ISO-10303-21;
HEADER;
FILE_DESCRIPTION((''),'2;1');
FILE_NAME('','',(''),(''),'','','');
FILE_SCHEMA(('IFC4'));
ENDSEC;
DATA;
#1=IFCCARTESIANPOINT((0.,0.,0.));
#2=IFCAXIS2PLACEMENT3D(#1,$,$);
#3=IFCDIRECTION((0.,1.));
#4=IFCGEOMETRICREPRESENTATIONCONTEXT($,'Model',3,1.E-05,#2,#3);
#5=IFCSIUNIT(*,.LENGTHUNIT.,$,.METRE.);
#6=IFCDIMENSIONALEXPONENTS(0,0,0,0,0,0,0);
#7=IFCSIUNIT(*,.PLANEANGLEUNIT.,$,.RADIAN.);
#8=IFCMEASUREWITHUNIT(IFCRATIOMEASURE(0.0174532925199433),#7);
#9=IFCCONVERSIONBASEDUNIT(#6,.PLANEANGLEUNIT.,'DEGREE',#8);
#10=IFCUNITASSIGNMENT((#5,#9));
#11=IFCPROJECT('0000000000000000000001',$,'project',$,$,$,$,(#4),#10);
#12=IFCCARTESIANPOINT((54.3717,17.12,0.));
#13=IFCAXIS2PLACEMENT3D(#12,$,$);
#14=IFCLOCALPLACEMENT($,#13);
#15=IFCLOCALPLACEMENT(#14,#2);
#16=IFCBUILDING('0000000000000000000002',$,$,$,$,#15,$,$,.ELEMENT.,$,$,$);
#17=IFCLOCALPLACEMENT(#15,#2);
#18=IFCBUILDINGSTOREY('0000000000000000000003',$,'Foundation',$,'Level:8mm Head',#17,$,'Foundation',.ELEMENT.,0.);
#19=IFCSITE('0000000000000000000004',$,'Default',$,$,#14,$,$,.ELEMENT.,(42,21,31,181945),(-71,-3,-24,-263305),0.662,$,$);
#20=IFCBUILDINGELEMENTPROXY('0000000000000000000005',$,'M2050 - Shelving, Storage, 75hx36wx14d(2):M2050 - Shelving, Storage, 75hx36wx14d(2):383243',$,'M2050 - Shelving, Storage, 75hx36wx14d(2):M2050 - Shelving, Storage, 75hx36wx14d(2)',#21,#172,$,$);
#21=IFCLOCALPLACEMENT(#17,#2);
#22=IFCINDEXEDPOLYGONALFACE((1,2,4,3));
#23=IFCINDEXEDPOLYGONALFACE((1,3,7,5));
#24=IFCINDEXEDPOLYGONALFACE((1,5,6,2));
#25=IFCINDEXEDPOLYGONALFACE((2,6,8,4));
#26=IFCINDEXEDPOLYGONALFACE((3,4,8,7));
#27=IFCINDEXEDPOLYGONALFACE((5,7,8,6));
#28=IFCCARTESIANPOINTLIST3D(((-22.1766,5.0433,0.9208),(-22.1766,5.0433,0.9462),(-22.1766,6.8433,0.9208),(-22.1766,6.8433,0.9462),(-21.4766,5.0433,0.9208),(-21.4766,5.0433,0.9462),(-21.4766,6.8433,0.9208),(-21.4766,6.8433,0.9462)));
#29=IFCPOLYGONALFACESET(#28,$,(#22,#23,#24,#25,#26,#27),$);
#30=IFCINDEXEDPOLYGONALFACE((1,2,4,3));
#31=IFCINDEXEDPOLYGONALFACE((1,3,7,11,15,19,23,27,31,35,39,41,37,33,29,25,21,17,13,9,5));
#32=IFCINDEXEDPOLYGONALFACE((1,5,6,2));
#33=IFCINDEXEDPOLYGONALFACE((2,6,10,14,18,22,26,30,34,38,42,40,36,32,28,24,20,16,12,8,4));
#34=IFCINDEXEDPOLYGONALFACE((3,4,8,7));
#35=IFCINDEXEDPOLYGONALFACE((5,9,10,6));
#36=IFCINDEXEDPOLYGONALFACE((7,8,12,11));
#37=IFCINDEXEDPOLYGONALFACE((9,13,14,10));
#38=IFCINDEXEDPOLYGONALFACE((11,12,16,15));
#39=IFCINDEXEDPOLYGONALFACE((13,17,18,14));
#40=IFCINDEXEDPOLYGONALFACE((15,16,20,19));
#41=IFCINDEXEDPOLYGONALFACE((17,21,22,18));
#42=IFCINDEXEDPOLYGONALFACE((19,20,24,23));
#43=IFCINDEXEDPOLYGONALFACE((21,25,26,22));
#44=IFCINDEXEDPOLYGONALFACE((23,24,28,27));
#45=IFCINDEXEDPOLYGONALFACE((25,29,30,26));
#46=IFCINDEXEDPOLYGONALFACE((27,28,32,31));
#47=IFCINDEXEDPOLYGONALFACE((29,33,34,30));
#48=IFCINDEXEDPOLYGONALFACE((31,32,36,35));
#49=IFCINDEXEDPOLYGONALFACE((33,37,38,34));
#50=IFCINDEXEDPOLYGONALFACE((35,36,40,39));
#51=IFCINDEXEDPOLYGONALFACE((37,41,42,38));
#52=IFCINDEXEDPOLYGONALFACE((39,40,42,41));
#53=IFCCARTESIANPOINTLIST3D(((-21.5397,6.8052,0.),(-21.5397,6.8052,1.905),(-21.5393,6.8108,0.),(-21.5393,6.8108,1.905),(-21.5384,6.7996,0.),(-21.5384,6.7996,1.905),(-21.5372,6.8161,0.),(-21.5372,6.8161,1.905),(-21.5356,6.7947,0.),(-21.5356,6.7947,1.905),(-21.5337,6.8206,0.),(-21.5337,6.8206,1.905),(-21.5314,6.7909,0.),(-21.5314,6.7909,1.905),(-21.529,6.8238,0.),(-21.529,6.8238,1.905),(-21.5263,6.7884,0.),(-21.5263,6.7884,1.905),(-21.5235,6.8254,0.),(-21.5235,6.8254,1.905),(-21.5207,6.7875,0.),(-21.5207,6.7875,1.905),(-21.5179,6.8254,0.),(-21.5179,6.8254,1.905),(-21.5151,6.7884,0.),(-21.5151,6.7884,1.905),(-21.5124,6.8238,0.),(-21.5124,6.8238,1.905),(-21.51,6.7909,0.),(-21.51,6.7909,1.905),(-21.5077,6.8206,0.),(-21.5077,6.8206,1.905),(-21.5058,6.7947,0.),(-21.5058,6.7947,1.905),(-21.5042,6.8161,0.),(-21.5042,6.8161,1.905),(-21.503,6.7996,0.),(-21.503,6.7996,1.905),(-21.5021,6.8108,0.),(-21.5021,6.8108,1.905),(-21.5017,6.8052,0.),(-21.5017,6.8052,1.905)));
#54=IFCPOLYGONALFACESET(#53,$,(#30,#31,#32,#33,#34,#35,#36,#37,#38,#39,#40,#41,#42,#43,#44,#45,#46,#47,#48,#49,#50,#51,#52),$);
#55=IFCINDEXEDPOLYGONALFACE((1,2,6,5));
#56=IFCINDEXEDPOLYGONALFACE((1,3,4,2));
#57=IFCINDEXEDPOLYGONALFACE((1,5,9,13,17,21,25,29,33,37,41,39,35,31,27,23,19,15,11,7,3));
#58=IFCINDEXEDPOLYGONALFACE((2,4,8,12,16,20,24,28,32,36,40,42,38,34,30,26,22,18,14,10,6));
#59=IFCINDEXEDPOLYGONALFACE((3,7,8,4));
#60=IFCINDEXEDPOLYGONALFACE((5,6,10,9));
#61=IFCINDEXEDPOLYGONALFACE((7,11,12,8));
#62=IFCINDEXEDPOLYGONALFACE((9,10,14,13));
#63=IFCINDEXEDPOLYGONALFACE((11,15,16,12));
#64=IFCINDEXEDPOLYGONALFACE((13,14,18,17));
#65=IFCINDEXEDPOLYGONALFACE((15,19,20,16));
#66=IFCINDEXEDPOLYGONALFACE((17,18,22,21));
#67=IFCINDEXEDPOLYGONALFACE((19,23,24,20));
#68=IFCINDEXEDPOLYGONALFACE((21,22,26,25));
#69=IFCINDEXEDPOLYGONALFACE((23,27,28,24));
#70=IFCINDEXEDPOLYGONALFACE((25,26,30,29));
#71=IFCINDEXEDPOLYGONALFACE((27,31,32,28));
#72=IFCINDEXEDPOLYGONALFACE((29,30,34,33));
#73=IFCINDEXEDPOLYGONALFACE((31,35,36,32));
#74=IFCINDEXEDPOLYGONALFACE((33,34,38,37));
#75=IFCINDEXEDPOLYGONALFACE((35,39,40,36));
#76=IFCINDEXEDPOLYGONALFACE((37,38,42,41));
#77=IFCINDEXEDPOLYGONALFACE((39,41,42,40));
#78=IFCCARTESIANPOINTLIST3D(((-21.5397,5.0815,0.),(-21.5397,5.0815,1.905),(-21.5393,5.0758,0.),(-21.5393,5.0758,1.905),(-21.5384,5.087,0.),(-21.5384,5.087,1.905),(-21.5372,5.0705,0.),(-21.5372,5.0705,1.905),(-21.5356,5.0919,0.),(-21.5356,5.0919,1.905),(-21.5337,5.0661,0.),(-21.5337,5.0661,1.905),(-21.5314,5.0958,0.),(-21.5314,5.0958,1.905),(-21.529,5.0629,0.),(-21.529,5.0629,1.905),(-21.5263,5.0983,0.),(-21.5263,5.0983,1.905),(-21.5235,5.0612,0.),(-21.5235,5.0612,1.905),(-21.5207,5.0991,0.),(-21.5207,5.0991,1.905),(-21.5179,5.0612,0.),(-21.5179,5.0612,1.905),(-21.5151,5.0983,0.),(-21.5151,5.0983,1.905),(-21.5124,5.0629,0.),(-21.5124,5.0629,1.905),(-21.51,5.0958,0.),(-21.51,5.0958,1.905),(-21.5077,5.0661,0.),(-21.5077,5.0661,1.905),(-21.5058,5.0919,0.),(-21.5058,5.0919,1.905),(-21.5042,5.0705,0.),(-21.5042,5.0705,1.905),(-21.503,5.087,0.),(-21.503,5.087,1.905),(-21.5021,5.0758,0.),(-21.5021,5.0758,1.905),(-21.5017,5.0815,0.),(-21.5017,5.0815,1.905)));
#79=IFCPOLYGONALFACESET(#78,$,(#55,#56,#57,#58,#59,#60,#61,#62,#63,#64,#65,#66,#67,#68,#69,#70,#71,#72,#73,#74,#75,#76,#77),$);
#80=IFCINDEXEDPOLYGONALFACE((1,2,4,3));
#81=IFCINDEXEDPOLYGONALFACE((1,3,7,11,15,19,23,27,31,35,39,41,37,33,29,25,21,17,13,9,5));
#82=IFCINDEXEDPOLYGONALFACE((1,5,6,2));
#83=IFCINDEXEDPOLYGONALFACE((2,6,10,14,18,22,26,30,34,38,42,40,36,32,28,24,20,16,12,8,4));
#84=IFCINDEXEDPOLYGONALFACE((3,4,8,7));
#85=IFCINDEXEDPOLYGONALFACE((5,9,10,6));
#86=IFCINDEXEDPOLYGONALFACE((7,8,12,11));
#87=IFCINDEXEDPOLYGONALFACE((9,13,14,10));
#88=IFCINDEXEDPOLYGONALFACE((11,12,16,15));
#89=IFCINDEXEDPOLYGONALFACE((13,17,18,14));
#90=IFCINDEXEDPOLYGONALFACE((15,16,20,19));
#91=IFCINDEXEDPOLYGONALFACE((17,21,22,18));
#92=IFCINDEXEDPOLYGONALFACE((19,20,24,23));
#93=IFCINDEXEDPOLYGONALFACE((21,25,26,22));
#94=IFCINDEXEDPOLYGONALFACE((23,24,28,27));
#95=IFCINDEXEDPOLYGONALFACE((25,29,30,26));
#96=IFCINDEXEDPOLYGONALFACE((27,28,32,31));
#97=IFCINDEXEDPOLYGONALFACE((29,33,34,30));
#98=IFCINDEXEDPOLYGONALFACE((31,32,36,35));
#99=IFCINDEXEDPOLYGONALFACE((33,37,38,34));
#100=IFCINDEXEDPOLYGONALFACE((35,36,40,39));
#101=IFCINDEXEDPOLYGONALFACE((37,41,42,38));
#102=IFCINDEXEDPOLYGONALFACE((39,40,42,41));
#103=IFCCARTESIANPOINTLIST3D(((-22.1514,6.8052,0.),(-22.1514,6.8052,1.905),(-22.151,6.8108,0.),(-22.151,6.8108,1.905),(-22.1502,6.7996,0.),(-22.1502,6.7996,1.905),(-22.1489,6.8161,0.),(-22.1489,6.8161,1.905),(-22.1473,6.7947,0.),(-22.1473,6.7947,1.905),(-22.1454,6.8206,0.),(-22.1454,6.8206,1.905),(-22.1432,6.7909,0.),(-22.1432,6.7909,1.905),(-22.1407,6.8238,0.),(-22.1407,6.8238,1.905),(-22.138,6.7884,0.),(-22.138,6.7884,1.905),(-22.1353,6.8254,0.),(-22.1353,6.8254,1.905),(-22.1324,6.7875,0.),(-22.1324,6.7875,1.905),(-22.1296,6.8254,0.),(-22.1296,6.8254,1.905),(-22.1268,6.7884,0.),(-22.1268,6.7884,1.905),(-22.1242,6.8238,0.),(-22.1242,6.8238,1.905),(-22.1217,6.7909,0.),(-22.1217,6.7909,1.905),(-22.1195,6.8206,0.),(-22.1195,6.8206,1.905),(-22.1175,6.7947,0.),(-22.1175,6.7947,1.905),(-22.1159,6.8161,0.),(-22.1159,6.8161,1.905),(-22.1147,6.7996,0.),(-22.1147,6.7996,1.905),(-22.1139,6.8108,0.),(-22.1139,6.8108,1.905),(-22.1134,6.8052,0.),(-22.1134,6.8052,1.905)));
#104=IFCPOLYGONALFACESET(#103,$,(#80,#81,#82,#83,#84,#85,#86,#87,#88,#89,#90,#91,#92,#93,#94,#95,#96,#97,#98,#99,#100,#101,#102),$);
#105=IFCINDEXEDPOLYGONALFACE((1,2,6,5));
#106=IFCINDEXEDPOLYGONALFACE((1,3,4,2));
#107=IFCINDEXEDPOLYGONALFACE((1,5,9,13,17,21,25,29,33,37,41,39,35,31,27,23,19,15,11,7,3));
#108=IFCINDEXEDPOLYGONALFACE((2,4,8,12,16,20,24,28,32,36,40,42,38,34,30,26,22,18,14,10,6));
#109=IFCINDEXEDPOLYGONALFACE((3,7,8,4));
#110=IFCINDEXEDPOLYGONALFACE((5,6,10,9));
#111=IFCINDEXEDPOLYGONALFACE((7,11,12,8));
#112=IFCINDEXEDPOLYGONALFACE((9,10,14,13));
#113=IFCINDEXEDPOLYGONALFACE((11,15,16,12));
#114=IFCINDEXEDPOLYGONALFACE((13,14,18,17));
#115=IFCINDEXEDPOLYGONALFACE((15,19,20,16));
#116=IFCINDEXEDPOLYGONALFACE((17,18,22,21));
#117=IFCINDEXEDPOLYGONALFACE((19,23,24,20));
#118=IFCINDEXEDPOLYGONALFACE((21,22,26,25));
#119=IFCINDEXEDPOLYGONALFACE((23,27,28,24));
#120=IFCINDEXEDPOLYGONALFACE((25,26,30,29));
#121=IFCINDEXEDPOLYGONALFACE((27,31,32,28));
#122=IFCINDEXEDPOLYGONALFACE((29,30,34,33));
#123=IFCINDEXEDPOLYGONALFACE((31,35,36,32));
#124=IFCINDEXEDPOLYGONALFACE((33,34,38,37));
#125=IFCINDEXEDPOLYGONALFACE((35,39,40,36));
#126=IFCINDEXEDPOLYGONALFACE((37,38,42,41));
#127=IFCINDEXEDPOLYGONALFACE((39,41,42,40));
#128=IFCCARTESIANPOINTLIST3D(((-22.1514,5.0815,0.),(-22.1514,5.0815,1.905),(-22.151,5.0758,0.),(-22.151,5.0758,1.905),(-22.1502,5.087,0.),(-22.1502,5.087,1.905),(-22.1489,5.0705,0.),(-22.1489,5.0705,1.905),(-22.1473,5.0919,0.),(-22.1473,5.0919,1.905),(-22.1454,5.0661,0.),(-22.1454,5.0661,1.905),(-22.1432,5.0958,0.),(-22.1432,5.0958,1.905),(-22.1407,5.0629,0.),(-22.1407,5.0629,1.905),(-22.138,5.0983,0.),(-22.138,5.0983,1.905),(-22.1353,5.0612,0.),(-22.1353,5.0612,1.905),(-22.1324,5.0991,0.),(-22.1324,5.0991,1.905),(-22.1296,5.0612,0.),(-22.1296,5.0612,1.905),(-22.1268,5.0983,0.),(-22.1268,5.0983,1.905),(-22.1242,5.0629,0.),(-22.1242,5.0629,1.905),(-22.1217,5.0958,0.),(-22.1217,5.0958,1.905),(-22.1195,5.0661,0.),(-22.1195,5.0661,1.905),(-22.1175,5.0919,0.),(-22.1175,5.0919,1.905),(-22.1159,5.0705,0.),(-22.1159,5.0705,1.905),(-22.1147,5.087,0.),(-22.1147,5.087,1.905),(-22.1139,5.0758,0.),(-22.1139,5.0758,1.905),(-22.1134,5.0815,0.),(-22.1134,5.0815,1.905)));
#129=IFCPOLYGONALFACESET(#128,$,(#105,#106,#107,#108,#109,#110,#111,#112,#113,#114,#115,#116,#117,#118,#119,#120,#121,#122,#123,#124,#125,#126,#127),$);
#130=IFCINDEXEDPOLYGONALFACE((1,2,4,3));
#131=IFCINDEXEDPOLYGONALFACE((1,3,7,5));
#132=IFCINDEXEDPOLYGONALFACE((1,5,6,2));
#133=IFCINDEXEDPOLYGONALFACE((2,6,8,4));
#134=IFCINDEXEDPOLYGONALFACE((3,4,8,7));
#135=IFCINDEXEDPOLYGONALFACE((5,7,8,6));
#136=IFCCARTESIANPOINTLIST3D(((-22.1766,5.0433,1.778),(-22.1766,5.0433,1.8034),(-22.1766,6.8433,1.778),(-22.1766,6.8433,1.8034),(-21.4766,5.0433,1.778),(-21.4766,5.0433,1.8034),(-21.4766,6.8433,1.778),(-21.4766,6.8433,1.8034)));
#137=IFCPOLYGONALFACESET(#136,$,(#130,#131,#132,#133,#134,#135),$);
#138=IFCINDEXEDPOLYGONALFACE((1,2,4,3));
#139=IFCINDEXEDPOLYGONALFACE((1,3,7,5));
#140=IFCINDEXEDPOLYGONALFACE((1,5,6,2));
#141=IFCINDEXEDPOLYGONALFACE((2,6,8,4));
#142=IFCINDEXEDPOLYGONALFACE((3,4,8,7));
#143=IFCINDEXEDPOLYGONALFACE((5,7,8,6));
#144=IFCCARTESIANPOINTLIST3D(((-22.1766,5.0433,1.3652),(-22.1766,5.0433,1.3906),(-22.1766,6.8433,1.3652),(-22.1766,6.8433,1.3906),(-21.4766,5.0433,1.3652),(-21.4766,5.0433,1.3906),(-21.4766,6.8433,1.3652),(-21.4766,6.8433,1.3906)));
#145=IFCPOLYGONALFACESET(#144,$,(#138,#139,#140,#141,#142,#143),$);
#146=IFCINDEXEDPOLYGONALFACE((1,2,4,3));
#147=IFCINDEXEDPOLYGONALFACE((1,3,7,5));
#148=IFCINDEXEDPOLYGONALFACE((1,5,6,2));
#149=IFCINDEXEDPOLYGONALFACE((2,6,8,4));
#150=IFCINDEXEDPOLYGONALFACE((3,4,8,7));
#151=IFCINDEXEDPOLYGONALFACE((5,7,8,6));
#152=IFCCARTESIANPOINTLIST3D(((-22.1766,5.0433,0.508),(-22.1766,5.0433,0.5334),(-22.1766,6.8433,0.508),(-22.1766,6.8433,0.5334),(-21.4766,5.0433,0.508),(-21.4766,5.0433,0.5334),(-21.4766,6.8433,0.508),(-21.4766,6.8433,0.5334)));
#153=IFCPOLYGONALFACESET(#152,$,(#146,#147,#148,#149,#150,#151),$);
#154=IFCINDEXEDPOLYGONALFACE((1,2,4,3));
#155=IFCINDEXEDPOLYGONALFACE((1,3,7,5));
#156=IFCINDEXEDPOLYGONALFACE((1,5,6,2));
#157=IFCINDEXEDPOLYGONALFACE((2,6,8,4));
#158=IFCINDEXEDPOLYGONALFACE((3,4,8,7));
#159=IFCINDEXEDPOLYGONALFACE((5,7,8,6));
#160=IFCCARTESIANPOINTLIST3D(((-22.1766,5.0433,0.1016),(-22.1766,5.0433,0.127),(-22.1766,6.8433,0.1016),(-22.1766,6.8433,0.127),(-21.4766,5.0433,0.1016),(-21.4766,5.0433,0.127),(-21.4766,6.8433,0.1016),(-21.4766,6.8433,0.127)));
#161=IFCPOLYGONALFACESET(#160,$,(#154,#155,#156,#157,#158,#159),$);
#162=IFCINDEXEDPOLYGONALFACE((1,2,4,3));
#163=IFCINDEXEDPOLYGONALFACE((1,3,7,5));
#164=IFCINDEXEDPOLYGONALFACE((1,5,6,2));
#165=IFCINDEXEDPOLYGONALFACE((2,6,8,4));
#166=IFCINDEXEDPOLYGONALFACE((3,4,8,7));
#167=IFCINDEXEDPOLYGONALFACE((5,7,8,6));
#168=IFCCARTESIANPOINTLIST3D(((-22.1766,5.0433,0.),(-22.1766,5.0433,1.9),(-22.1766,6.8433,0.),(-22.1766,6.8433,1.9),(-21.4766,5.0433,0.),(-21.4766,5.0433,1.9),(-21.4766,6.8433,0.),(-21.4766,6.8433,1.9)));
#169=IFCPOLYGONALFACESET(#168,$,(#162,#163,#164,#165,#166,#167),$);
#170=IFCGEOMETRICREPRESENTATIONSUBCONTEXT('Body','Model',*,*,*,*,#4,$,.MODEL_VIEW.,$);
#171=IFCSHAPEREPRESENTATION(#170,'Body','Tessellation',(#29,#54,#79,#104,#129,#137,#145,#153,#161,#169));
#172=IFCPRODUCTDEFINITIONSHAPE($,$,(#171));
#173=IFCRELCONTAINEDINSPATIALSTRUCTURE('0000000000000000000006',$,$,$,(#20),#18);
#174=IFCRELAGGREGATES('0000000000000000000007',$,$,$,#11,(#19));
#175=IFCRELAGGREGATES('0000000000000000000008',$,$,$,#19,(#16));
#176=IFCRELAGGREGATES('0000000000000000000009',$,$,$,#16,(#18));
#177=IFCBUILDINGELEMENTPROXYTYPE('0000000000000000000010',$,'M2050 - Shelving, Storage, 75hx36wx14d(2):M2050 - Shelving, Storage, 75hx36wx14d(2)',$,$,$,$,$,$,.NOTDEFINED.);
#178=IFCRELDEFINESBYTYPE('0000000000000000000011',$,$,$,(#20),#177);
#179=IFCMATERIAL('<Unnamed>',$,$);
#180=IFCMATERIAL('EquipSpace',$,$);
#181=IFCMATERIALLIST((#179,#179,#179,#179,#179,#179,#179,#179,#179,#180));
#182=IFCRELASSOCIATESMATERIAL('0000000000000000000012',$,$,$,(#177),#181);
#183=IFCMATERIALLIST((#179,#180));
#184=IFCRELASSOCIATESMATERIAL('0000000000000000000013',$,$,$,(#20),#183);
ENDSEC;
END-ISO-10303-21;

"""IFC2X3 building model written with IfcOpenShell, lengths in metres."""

from ifc_helpers import new_model, entity, si_unit, converted_unit, direction, frame, frame_2d, origin, origin_2d_with_axis, place, context, subcontext, project, spatial, rectangle, circle, extrude, source, transform, mapped, material, material_list, type_object, type_shapes, element, save


model = new_model("IFC2X3")

# Units and contexts
model_context = context("Model", 3, precision=1e-05, world=origin(), true_north=direction((0.0, 1.0)))
body_context = subcontext(model_context, "Body", "Model", "MODEL_VIEW")
ifc_project = project(units=[si_unit("LENGTHUNIT", "METRE"), converted_unit("PLANEANGLEUNIT", "DEGREE", entity("IfcRatioMeasure", 0.0174532925199433), si_unit("PLANEANGLEUNIT", "RADIAN"), dimensions=[0, 0, 0, 0, 0, 0, 0])], contexts=[model_context])

# Site, building, storey
site_placement = place(None, frame((54.3717, 17.12, 0.0)))
site = spatial("IfcSite", under=ifc_project, at=site_placement, Name="Default", CompositionType="ELEMENT", RefLatitude=(42, 21, 31, 181945), RefLongitude=(-71, -3, -24, -263305), RefElevation=0.662)
building_placement = place(site_placement, origin())
building = spatial("IfcBuilding", under=site, at=building_placement, CompositionType="ELEMENT")
storey_placement = place(building_placement, origin())
storey = spatial("IfcBuildingStorey", under=building, at=storey_placement, Name="Foundation", ObjectType="Level:8mm Head", LongName="Foundation", CompositionType="ELEMENT", Elevation=0.0)

# Building element proxy
ifc_material_1 = material(Name="<Unnamed>")
ifc_material_2 = material(Name="EquipSpace")
ifc_material_list_1 = material_list([ifc_material_1, ifc_material_1, ifc_material_1, ifc_material_1, ifc_material_1, ifc_material_1, ifc_material_1, ifc_material_1, ifc_material_1, ifc_material_2])
building_element_proxy_type = type_object("IfcBuildingElementProxyType", Name="M2050 - Shelving, Storage, 75hx36wx14d(2):M2050 - Shelving, Storage, 75hx36wx14d(2)", PredefinedType="NOTDEFINED", material=ifc_material_list_1)
shared_shape = source(origin(), body_context, "Body", "SweptSolid", [
    extrude(rectangle(XDim=1.8, YDim=0.7, at=origin_2d_with_axis()), frame((0.0, 0.0, 0.9207), z_axis=(0.0, 0.0, 1.0), x_axis=(-1.0, 0.0, 0.0)), (0.0, 0.0, 1.0), 0.0254),
    extrude(circle(Radius=0.0191, at=origin_2d_with_axis()), frame((0.8633, -0.3059, 0.0), z_axis=(0.0, 0.0, 1.0), x_axis=(-1.0, 0.0, 0.0)), (0.0, 0.0, 1.0), 1.905),
    extrude(circle(Radius=0.0191, at=origin_2d_with_axis()), frame((-0.8633, -0.3059, 0.0)), (0.0, 0.0, 1.0), 1.905),
    extrude(circle(Radius=0.0191, at=origin_2d_with_axis()), frame((0.8633, 0.3059, 0.0), z_axis=(0.0, 0.0, 1.0), x_axis=(-1.0, 0.0, 0.0)), (0.0, 0.0, 1.0), 1.905),
    extrude(circle(Radius=0.0191, at=origin_2d_with_axis()), frame((-0.8633, 0.3059, 0.0)), (0.0, 0.0, 1.0), 1.905),
    extrude(rectangle(XDim=1.8, YDim=0.7, at=origin_2d_with_axis()), frame((0.0, 0.0, 1.778), z_axis=(0.0, 0.0, 1.0), x_axis=(-1.0, 0.0, 0.0)), (0.0, 0.0, 1.0), 0.0254),
    extrude(rectangle(XDim=1.8, YDim=0.7, at=origin_2d_with_axis()), frame((0.0, 0.0, 1.3653), z_axis=(0.0, 0.0, 1.0), x_axis=(-1.0, 0.0, 0.0)), (0.0, 0.0, 1.0), 0.0254),
    extrude(rectangle(XDim=1.8, YDim=0.7, at=origin_2d_with_axis()), frame((0.0, 0.0, 0.508), z_axis=(0.0, 0.0, 1.0), x_axis=(-1.0, 0.0, 0.0)), (0.0, 0.0, 1.0), 0.0254),
    extrude(rectangle(XDim=1.8, YDim=0.7, at=origin_2d_with_axis()), frame((0.0, 0.0, 0.1016), z_axis=(0.0, 0.0, 1.0), x_axis=(-1.0, 0.0, 0.0)), (0.0, 0.0, 1.0), 0.0254),
    extrude(rectangle(XDim=0.7, YDim=1.8, at=frame_2d((0.0, 0.18), x_axis=(1.0, 0.0))), frame((-0.18, 0.0, 0.0), z_axis=(0.0, 0.0, 1.0), x_axis=(0.0, -1.0, 0.0)), (0.0, 0.0, 1.0), 1.9),
])
type_shapes(building_element_proxy_type, [shared_shape])
ifc_material_list_2 = material_list([ifc_material_1, ifc_material_2])
proxy_1_placement = place(storey_placement, frame((-21.8266, 5.9433, 0.0), z_axis=(0.0, 0.0, 1.0), x_axis=(0.0, 1.0, 0.0)))
element("IfcBuildingElementProxy", 1, at=proxy_1_placement, inside=storey, type_object=building_element_proxy_type, material=ifc_material_list_2, Name="M2050 - Shelving, Storage, 75hx36wx14d(2):M2050 - Shelving, Storage, 75hx36wx14d(2):383243", ObjectType="M2050 - Shelving, Storage, 75hx36wx14d(2):M2050 - Shelving, Storage, 75hx36wx14d(2)", context=body_context, shape_type="MappedRepresentation", body=[
    mapped(shared_shape, transform((0.0, 0.0, 0.0), scale=1.0)),
])

save(model, "model.ifc")
